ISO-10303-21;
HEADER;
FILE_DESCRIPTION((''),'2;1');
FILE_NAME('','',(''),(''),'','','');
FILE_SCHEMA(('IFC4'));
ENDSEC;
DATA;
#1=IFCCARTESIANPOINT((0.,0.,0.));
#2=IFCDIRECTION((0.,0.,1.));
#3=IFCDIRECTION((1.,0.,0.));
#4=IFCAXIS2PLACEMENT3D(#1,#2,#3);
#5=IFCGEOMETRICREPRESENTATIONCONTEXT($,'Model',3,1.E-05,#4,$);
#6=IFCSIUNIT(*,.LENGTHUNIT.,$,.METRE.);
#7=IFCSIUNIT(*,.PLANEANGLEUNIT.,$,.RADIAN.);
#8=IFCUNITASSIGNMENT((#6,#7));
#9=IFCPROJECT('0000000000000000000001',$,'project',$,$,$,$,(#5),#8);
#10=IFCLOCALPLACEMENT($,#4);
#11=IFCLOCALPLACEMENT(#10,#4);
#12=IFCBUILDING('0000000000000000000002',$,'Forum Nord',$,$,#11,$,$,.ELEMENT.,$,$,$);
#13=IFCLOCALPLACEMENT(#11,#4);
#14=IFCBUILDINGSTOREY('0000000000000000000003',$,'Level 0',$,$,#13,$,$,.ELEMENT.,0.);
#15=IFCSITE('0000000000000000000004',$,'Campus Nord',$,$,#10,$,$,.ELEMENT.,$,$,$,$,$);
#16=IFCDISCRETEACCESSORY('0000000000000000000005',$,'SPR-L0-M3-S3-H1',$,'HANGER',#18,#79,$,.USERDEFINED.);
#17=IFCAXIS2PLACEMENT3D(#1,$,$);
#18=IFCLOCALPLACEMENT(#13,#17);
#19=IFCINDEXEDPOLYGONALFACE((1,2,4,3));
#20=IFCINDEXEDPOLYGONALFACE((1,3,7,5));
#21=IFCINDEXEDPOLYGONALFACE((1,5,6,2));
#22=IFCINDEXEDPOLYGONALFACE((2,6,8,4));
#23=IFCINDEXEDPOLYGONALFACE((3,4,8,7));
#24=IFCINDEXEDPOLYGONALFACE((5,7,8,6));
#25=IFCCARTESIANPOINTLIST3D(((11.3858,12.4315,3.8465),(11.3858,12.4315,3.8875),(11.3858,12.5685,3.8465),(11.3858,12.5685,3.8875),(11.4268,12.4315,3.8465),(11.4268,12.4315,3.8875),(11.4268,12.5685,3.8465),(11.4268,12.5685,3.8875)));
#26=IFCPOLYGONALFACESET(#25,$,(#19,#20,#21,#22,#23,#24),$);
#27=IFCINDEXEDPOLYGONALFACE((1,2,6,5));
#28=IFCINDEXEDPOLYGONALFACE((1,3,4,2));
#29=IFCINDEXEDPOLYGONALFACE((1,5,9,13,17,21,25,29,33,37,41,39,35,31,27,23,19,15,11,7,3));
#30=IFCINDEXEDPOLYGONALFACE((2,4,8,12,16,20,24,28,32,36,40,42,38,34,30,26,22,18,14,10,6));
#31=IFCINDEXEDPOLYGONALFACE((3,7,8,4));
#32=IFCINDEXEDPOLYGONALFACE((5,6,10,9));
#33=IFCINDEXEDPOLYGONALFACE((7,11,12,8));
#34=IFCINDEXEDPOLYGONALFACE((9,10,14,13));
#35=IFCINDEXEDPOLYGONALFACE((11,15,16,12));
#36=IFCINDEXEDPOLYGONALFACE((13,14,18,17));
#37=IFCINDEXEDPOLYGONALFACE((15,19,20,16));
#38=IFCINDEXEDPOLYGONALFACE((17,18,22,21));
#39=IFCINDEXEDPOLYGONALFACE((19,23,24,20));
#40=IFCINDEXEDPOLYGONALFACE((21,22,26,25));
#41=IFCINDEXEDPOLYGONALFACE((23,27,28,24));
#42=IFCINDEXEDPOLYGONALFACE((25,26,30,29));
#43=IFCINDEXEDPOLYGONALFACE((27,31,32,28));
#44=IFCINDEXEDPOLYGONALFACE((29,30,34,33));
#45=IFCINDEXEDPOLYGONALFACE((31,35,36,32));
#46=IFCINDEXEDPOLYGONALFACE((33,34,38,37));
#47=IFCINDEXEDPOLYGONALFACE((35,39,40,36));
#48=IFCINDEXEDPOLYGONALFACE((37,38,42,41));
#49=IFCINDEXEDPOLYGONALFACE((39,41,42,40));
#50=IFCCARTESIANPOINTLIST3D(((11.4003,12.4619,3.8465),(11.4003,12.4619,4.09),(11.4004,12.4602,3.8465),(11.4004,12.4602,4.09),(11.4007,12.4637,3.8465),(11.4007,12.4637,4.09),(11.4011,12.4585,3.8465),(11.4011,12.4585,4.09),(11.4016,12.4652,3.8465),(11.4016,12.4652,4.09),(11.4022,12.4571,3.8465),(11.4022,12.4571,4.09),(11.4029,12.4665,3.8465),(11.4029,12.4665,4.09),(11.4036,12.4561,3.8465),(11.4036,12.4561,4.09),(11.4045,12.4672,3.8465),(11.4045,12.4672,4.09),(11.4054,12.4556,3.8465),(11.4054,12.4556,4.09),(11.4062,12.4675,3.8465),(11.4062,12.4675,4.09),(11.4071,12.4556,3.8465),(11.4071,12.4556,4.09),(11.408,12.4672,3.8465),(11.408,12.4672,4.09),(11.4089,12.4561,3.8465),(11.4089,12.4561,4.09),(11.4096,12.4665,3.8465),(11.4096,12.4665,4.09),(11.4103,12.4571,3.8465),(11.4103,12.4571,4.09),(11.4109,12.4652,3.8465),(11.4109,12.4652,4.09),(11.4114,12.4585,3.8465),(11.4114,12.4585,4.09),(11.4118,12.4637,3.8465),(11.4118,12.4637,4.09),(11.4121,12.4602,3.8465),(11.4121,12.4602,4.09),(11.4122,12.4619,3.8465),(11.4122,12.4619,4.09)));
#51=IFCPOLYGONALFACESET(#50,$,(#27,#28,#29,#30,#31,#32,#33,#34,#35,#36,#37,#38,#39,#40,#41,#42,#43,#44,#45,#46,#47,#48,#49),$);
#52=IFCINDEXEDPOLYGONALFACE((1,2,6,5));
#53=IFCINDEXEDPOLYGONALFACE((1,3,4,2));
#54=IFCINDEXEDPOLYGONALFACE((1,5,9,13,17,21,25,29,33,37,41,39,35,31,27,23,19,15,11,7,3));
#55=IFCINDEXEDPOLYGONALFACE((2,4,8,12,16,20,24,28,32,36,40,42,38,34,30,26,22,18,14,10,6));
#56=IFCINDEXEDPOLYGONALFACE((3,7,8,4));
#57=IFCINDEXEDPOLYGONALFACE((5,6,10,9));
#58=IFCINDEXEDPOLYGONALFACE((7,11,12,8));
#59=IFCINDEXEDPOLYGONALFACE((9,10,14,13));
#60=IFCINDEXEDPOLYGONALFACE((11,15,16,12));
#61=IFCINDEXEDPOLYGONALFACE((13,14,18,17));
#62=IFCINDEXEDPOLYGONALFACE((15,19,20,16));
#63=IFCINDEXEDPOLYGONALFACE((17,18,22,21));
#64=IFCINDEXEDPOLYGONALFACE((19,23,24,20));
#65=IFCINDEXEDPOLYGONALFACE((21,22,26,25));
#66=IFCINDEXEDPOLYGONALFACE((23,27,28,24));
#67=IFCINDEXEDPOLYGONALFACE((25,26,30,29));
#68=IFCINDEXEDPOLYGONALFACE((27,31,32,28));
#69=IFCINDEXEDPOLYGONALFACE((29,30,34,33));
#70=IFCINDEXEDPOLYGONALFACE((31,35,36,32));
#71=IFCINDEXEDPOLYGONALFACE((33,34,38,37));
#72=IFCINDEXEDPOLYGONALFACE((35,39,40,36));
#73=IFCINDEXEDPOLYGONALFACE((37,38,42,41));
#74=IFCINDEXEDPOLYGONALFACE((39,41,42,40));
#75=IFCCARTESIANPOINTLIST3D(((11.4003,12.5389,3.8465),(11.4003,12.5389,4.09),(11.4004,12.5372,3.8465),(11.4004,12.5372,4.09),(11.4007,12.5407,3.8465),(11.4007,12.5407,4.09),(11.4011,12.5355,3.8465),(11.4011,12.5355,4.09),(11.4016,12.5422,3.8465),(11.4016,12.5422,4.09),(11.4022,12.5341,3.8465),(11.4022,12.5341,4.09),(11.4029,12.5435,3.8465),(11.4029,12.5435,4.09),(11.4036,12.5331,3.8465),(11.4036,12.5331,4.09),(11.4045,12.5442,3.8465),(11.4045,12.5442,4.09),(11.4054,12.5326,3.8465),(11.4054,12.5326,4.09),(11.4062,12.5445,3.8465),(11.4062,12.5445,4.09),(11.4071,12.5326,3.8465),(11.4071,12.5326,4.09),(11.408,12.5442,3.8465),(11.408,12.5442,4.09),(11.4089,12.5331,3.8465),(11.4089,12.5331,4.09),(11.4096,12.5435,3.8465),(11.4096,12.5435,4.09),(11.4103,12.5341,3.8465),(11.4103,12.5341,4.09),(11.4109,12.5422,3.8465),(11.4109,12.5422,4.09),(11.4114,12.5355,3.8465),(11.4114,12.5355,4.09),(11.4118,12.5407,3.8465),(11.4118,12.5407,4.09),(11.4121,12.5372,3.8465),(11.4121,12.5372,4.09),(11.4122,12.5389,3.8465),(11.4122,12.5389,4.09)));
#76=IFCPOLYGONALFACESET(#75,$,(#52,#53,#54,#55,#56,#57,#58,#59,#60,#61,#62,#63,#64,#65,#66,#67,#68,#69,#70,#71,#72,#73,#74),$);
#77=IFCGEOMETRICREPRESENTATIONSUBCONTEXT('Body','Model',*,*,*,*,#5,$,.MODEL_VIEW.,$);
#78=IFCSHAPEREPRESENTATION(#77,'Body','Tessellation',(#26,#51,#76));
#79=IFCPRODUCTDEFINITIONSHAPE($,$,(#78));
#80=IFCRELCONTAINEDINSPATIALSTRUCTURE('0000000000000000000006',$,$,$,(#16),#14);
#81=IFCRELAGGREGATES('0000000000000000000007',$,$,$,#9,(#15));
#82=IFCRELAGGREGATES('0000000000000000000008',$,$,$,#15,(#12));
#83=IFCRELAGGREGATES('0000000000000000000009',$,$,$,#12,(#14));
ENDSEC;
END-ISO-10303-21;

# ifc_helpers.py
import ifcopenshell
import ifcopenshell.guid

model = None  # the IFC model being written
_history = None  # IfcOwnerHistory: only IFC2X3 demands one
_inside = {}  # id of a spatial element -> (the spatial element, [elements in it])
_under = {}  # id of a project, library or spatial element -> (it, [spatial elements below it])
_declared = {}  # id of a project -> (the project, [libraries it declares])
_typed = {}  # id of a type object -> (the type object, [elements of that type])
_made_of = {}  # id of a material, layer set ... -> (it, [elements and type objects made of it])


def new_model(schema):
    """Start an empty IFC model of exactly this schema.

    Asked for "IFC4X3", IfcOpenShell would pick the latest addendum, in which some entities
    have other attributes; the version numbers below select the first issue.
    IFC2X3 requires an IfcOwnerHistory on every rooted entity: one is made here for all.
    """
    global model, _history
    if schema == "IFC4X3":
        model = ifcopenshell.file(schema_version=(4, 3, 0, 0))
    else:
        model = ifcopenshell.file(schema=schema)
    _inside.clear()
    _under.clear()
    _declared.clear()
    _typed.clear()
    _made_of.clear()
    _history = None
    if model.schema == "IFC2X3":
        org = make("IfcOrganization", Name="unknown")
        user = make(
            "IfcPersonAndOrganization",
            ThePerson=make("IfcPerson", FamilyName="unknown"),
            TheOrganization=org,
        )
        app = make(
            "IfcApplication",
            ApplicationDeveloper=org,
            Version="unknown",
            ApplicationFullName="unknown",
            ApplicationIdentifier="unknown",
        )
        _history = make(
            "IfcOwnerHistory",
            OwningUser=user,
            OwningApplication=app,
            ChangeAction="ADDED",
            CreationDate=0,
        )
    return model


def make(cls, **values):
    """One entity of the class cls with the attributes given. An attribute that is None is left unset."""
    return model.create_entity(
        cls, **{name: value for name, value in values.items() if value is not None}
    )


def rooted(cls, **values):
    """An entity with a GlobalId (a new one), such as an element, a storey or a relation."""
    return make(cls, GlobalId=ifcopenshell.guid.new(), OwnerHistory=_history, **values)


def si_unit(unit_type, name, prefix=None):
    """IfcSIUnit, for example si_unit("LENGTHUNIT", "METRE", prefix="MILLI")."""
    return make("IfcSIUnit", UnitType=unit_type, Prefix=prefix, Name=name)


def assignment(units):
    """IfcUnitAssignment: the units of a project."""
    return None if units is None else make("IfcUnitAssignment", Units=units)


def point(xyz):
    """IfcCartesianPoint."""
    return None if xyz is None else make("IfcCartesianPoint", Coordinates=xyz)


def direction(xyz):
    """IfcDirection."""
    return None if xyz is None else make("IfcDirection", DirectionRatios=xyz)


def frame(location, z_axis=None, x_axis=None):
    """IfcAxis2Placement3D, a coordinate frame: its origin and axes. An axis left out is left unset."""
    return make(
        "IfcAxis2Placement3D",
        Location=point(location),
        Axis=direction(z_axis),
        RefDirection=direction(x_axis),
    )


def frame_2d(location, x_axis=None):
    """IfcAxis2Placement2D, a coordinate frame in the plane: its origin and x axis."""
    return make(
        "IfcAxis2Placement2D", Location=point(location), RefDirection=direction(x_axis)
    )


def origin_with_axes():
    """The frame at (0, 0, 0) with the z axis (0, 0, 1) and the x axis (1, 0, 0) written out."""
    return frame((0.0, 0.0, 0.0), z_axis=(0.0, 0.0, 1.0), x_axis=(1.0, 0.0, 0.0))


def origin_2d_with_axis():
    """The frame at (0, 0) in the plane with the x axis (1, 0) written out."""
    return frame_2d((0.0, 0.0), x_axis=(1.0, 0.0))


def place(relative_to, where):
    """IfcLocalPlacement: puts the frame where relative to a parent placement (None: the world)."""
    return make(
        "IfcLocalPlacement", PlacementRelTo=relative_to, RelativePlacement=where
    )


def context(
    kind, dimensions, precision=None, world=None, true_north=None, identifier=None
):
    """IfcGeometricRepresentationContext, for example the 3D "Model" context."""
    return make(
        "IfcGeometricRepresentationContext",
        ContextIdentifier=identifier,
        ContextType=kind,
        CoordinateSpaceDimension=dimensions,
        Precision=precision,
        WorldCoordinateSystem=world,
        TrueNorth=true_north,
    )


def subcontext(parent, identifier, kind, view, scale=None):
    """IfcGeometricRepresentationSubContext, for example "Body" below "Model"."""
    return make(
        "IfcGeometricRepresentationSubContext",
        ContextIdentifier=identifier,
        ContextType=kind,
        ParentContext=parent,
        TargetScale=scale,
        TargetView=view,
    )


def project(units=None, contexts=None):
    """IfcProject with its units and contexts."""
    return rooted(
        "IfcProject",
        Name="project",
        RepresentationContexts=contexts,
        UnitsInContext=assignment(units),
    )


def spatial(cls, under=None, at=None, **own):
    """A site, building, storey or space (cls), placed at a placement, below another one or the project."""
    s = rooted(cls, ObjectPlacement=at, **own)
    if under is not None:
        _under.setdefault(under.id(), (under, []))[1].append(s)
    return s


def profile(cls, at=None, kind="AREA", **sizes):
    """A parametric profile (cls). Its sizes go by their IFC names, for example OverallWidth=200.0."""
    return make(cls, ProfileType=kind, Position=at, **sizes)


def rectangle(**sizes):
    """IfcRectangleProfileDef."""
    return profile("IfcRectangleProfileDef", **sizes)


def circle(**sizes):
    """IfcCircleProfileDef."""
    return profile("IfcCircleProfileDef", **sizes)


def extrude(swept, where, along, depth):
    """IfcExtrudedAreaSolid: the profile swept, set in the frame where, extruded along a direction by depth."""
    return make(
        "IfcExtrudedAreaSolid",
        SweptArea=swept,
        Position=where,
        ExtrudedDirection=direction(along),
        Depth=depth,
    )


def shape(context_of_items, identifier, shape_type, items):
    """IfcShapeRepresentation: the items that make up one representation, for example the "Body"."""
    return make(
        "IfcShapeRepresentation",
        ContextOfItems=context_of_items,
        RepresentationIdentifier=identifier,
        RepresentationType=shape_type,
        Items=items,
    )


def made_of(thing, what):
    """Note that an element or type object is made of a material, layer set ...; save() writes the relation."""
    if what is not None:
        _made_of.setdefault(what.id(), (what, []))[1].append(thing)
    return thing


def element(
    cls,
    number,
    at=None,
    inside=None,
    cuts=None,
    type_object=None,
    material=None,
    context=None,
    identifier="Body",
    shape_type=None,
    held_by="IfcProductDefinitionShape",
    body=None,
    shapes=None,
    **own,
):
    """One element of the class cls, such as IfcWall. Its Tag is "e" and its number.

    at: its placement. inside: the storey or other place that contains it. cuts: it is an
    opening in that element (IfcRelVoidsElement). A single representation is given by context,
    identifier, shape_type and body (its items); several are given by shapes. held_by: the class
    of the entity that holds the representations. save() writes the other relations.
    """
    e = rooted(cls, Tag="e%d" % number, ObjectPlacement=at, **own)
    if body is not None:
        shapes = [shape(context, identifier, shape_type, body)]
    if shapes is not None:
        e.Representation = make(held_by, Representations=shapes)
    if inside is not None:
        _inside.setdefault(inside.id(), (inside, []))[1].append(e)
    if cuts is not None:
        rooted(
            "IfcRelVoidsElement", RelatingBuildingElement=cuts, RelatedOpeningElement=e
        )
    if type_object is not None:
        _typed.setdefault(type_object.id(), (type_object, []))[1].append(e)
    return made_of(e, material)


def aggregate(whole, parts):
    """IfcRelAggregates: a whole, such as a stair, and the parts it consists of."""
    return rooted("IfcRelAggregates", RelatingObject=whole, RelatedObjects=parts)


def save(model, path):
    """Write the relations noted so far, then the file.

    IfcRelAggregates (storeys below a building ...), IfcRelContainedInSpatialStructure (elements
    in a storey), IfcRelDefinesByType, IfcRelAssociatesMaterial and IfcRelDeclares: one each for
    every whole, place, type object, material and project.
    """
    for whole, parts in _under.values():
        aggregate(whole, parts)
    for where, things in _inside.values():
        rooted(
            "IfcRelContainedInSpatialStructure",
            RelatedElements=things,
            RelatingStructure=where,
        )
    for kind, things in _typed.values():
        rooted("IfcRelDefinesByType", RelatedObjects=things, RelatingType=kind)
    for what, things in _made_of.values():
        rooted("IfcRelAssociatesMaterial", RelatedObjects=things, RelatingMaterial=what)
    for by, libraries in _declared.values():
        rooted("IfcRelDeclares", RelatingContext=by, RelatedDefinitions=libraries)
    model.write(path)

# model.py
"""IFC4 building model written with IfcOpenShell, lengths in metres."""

from ifc_helpers import new_model, si_unit, frame, frame_2d, origin_with_axes, origin_2d_with_axis, place, context, subcontext, project, spatial, rectangle, circle, extrude, element, save


model = new_model("IFC4")

# Units and contexts
model_context = context("Model", 3, precision=1e-05, world=origin_with_axes())
body_context = subcontext(model_context, "Body", "Model", "MODEL_VIEW")
ifc_project = project(units=[si_unit("LENGTHUNIT", "METRE"), si_unit("PLANEANGLEUNIT", "RADIAN")], contexts=[model_context])

# Site, building, storey
site_placement = place(None, origin_with_axes())
site = spatial("IfcSite", under=ifc_project, at=site_placement, Name="Campus Nord", CompositionType="ELEMENT")
building_placement = place(site_placement, origin_with_axes())
building = spatial("IfcBuilding", under=site, at=building_placement, Name="Forum Nord", CompositionType="ELEMENT")
storey_placement = place(building_placement, origin_with_axes())
storey = spatial("IfcBuildingStorey", under=building, at=storey_placement, Name="Level 0", CompositionType="ELEMENT", Elevation=0.0)

# Discrete accessory
for number, where, z_axis, x_axis, name in (
    (1, (11.4062, 12.5, 3.8875), (0.0, 0.0, 1.0), (0.0, 1.0, 0.0), "SPR-L0-M3-S3-H1"),
):
    element("IfcDiscreteAccessory", number, at=place(storey_placement, frame(where, z_axis=z_axis, x_axis=x_axis)), inside=storey, Name=name, ObjectType="HANGER", PredefinedType="USERDEFINED", context=body_context, shape_type="SweptSolid", body=[
        extrude(rectangle(XDim=0.137, YDim=0.041, at=origin_2d_with_axis()), frame((0.0, 0.0, -0.041), z_axis=(0.0, 0.0, 1.0), x_axis=(1.0, 0.0, 0.0)), (0.0, 0.0, 1.0), 0.041),
        extrude(circle(Radius=0.006, at=frame_2d((-0.0385, 0.0), x_axis=(1.0, 0.0))), frame((0.0, 0.0, -0.041), z_axis=(0.0, 0.0, 1.0), x_axis=(1.0, 0.0, 0.0)), (0.0, 0.0, 1.0), 0.2435),
        extrude(circle(Radius=0.006, at=frame_2d((0.0385, 0.0), x_axis=(1.0, 0.0))), frame((0.0, 0.0, -0.041), z_axis=(0.0, 0.0, 1.0), x_axis=(1.0, 0.0, 0.0)), (0.0, 0.0, 1.0), 0.2435),
    ])

save(model, "model.ifc")
